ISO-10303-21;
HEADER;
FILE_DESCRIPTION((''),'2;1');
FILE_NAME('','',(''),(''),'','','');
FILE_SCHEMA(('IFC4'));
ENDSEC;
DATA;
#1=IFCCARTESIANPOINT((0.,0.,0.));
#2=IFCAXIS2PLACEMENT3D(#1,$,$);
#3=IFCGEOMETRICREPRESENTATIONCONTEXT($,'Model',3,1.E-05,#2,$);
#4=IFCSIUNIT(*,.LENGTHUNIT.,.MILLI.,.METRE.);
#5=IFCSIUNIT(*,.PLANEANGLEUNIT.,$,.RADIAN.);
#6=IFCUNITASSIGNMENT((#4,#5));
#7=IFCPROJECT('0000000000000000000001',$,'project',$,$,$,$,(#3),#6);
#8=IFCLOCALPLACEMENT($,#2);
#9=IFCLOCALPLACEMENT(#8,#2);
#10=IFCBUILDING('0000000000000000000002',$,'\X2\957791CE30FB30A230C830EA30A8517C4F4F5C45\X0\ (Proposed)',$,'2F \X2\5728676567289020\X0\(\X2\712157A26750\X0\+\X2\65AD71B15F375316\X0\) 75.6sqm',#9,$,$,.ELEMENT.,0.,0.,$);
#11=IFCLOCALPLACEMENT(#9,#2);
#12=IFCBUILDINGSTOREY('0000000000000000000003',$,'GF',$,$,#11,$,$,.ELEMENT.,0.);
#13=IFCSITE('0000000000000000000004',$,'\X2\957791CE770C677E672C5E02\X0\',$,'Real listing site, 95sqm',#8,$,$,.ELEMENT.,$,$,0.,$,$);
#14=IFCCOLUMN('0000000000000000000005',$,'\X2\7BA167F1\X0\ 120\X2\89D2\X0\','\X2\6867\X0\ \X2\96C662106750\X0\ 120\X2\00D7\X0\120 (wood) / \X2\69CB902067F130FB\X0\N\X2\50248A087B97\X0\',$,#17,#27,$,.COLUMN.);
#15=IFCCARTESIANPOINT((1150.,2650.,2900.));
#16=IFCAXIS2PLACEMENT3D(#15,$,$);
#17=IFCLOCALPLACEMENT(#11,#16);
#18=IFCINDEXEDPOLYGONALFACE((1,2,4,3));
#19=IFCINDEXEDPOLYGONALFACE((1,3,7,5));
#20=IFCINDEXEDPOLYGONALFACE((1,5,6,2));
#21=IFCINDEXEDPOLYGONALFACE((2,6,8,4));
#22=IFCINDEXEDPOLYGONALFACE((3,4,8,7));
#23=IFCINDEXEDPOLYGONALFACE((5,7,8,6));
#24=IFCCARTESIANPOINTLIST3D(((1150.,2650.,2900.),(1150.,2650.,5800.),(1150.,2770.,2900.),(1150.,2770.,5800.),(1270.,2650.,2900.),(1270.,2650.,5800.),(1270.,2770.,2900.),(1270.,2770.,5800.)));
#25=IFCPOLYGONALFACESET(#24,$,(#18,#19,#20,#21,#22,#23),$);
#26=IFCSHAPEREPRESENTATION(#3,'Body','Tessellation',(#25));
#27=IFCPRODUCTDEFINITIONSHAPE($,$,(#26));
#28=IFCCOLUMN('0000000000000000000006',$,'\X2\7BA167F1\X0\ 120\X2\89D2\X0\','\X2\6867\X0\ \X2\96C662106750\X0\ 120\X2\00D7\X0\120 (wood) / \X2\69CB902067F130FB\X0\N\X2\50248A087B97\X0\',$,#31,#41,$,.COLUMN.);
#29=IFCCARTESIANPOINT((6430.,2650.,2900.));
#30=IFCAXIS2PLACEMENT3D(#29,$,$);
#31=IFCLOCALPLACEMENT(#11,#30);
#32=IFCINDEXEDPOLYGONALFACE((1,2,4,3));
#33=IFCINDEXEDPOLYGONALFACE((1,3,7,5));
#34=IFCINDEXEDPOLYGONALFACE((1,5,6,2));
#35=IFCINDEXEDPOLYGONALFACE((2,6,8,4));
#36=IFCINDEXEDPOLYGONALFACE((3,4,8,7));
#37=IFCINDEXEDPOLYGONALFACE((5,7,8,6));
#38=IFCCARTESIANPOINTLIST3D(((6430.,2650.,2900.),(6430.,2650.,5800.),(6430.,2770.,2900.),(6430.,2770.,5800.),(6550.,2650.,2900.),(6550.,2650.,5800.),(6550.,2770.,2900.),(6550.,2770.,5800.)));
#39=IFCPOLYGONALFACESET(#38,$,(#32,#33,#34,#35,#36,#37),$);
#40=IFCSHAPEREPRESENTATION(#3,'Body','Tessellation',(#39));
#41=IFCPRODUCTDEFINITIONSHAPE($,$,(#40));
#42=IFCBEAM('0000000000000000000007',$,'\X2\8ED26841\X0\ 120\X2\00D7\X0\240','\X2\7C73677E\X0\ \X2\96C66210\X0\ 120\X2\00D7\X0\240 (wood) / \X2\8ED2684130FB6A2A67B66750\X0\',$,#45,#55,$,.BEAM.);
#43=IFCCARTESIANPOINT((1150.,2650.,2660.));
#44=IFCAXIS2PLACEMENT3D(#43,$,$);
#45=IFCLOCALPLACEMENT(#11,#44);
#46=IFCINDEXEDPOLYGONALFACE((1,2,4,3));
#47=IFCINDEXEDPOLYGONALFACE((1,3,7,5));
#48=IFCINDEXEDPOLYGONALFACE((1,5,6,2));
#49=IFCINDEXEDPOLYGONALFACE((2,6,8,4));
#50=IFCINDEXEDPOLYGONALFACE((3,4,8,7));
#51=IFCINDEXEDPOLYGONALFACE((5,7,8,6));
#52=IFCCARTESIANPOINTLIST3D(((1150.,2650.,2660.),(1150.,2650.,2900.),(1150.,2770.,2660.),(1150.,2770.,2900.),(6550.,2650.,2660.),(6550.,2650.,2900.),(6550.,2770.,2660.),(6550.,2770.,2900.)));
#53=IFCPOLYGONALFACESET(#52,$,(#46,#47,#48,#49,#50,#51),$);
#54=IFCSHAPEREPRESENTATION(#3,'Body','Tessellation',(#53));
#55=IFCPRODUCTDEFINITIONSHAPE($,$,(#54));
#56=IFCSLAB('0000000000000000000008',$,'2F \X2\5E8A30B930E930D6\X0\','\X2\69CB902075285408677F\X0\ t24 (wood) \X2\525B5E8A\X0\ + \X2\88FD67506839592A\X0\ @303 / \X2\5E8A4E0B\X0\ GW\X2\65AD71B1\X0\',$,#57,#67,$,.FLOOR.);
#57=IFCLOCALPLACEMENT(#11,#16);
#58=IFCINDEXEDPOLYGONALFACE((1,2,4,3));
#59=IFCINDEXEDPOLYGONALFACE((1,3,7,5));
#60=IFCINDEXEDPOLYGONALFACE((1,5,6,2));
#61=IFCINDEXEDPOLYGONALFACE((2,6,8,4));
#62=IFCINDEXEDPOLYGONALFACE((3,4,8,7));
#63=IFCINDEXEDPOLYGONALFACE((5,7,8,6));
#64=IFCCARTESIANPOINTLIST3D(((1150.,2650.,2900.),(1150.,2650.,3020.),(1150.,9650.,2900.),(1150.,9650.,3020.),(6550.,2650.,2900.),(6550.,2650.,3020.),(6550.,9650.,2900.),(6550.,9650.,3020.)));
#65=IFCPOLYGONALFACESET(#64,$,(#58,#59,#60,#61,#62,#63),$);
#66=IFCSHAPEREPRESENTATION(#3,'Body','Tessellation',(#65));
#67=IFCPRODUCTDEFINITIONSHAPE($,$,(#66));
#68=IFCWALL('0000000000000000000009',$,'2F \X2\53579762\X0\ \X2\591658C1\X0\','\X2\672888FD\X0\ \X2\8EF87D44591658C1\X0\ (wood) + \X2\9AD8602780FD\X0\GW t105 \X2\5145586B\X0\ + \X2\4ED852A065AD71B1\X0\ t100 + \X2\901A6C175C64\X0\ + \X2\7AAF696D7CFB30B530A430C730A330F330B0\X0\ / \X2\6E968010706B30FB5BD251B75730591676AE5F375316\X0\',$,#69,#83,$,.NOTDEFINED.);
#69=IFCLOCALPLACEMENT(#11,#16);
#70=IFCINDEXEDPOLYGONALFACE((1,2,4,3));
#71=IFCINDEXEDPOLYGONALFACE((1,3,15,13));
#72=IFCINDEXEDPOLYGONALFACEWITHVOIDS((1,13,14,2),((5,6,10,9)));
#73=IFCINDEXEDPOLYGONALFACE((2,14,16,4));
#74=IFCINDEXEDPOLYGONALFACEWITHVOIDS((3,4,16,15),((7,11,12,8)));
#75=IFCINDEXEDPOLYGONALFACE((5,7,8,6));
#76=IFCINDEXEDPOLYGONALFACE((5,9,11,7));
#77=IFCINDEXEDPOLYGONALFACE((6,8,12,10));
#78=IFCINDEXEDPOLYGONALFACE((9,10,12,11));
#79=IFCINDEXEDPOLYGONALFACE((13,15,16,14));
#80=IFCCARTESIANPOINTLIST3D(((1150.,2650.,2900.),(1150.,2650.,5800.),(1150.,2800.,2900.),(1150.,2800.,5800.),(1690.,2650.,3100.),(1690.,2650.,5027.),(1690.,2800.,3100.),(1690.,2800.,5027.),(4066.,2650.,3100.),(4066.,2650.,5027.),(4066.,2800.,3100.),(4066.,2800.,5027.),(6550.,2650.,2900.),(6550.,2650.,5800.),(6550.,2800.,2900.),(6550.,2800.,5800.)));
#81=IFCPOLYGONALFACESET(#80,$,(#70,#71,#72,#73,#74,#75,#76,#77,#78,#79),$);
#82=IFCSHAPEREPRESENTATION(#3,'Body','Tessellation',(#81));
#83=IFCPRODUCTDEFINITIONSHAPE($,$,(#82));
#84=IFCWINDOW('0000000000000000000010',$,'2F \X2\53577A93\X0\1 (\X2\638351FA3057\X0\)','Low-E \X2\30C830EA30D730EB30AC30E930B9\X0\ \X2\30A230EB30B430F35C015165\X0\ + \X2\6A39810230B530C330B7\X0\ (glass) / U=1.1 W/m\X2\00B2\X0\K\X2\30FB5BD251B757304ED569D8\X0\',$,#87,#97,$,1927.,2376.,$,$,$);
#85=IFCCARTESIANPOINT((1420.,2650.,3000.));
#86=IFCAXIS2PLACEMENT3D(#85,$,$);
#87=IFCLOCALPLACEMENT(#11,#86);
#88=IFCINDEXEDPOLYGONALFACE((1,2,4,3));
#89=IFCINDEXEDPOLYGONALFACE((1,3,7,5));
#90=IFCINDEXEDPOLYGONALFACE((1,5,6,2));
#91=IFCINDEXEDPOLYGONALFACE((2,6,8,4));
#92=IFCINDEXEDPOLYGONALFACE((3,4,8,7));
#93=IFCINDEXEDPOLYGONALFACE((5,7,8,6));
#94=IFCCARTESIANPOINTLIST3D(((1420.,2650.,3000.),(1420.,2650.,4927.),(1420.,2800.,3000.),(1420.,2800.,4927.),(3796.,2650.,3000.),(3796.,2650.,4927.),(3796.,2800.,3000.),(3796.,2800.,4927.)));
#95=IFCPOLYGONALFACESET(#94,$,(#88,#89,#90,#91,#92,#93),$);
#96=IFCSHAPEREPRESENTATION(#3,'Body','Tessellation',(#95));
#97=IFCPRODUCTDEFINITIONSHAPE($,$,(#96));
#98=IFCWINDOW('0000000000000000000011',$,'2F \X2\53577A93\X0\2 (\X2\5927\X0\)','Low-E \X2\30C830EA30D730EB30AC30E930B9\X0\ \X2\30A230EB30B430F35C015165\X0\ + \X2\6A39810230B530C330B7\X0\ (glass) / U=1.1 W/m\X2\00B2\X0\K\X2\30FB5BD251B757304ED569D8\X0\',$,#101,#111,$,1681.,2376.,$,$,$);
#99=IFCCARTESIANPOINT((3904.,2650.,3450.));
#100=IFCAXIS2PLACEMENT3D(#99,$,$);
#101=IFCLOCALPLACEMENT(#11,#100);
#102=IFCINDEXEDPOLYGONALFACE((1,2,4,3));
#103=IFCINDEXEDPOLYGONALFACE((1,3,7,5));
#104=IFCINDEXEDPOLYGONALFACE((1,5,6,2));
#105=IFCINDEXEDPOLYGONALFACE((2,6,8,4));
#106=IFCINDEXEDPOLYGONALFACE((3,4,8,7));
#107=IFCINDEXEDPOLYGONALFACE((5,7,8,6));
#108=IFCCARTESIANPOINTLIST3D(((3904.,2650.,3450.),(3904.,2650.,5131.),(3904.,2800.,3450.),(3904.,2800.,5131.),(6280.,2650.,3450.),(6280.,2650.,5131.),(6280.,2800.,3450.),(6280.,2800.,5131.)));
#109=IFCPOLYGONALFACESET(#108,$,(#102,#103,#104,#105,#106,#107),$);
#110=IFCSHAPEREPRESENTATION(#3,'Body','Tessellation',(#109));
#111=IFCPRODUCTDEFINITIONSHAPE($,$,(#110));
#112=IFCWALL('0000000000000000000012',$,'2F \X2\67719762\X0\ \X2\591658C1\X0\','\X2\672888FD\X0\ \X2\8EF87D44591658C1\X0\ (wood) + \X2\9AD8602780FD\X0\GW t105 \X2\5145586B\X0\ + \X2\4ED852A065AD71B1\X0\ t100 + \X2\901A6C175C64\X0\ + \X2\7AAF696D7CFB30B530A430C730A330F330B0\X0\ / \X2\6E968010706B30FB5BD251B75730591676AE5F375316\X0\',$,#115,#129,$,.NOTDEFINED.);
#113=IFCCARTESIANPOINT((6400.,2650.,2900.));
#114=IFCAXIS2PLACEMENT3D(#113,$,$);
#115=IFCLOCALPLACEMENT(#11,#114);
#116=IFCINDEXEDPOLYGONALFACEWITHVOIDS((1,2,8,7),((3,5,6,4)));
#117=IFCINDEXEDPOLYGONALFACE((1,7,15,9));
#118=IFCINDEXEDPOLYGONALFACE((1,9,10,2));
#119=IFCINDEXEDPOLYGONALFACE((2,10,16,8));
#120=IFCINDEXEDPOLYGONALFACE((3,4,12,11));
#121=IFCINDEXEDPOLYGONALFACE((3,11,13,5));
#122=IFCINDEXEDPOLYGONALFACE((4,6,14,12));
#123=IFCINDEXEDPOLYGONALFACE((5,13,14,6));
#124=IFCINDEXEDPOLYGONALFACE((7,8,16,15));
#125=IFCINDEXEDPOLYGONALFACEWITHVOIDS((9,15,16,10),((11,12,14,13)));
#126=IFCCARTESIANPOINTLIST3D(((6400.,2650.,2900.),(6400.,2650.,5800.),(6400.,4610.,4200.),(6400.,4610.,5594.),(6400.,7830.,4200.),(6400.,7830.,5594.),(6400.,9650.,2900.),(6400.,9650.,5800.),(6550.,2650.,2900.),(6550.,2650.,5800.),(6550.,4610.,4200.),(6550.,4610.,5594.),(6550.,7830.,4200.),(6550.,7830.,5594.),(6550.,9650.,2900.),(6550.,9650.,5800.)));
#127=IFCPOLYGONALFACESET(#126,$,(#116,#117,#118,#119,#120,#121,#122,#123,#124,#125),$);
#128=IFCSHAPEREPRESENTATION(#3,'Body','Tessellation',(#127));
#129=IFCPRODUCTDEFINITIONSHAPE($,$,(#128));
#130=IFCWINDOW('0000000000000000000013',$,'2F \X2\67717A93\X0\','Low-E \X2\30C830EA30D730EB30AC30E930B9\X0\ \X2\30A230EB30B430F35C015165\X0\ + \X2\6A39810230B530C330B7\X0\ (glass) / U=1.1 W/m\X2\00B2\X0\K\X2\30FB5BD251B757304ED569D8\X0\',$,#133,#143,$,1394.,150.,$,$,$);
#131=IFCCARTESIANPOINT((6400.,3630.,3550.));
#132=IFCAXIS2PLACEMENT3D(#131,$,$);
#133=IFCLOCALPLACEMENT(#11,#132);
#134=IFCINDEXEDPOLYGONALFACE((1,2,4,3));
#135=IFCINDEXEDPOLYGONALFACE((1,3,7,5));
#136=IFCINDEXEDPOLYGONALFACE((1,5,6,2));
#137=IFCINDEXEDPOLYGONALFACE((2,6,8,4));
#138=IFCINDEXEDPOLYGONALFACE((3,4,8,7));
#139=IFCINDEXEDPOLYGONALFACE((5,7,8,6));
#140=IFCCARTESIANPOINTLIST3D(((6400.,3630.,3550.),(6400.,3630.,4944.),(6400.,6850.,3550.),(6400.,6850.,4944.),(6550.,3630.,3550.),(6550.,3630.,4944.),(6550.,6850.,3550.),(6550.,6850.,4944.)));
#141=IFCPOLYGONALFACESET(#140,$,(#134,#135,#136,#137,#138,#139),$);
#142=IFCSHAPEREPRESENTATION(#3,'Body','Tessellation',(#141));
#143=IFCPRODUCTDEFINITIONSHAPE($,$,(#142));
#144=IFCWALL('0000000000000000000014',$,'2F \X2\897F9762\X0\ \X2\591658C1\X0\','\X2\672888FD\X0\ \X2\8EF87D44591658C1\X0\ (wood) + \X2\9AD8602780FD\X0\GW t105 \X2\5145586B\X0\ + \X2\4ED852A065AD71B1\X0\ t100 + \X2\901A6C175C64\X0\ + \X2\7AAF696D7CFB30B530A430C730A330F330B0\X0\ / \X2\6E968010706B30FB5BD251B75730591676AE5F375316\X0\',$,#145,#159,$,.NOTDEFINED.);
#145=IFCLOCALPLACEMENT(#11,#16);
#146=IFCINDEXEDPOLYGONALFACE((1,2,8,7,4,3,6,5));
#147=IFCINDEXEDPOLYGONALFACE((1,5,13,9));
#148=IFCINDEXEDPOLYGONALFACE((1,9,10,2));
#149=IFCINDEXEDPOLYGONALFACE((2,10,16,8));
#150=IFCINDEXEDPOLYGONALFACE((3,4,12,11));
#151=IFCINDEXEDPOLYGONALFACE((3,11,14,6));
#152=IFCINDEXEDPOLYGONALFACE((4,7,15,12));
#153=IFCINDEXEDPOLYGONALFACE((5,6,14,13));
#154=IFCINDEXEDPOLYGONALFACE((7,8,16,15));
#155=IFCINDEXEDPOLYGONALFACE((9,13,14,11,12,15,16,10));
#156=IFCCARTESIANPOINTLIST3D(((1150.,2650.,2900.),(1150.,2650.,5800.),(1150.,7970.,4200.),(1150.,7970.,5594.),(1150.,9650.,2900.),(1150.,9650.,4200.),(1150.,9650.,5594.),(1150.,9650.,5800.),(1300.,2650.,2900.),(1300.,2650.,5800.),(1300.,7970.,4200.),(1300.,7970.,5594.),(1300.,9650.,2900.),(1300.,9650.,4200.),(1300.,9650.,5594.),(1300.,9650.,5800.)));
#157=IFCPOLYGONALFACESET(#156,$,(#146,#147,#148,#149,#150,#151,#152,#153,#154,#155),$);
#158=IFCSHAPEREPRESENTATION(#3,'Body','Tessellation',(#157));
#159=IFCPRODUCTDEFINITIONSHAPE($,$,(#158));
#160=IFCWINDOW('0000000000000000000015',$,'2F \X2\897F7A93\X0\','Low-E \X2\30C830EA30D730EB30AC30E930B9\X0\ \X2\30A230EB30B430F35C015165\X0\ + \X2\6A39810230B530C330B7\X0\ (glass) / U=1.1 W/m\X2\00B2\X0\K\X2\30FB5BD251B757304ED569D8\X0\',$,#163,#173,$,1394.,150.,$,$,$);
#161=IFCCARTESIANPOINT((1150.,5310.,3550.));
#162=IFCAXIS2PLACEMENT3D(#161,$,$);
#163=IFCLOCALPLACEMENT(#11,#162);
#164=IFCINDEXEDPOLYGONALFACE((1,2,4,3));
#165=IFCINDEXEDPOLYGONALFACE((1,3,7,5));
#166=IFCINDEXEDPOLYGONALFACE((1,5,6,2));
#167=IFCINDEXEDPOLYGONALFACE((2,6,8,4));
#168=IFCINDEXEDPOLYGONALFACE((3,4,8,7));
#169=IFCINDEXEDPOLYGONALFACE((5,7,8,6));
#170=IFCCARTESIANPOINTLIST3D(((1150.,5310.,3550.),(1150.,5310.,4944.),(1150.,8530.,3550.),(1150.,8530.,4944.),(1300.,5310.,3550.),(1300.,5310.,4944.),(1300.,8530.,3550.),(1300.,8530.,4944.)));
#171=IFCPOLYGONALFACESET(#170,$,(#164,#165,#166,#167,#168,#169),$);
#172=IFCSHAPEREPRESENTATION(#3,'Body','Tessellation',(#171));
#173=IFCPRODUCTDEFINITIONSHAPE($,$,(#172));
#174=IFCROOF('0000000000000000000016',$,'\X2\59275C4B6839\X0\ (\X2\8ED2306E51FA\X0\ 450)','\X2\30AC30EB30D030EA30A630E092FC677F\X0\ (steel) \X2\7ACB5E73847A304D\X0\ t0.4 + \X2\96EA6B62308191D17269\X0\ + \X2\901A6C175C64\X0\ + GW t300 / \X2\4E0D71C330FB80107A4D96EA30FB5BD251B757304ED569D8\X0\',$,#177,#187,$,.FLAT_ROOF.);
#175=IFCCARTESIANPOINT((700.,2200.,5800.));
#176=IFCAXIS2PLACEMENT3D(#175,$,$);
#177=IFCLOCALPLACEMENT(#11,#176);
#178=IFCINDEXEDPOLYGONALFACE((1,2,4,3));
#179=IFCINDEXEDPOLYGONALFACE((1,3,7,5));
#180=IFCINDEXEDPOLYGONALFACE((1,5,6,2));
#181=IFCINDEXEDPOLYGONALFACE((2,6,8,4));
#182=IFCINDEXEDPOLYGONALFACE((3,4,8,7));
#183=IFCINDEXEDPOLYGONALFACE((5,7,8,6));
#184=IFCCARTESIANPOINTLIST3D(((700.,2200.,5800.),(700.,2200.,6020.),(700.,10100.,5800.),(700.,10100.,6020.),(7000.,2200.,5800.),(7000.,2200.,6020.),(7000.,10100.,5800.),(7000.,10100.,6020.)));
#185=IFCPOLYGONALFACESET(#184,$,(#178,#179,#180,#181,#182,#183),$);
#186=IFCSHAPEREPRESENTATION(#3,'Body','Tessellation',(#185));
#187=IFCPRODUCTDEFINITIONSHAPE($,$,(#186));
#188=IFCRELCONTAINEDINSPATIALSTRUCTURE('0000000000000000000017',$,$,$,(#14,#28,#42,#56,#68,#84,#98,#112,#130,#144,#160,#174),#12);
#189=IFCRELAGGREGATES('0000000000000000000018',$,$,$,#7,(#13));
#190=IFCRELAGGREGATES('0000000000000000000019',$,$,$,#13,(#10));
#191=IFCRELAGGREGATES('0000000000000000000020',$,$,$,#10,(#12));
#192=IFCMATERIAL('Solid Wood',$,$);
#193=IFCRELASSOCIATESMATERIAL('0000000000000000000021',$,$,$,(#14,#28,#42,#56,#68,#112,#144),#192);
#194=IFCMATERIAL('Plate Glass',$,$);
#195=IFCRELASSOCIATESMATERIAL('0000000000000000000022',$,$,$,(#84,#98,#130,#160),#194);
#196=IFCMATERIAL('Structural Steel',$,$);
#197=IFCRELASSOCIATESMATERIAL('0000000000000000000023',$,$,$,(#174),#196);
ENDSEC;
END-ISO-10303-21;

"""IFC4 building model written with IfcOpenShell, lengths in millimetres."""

from ifc_helpers import new_model, si_unit, frame, frame_2d, origin, place, context, project, spatial, rectangle, extrude, material, element, fill, save


model = new_model("IFC4")

# Units and contexts
model_context = context("Model", 3, precision=1e-05, world=origin())
ifc_project = project(units=[si_unit("LENGTHUNIT", "METRE", prefix="MILLI"), si_unit("PLANEANGLEUNIT", "RADIAN")], contexts=[model_context])

# Site, building, storey
site_placement = place(None, origin())
site = spatial("IfcSite", under=ifc_project, at=site_placement, Name="長野県松本市", ObjectType="Real listing site, 95sqm", CompositionType="ELEMENT", RefElevation=0.0)
building_placement = place(site_placement, origin())
building = spatial("IfcBuilding", under=site, at=building_placement, Name="長野・アトリエ兼住居 (Proposed)", ObjectType="2F 在来木造(無垢材+断熱強化) 75.6sqm", CompositionType="ELEMENT", ElevationOfRefHeight=0.0, ElevationOfTerrain=0.0)
storey_placement = place(building_placement, origin())
storey = spatial("IfcBuildingStorey", under=building, at=storey_placement, Name="GF", CompositionType="ELEMENT", Elevation=0.0)

# Columns
ifc_material_1 = material(Name="Solid Wood")
column_1_placement = place(storey_placement, frame((1150.0, 2650.0, 2900.0)))
element("IfcColumn", 1, at=column_1_placement, inside=storey, material=ifc_material_1, Name="管柱 120角", Description="桧 集成材 120×120 (wood) / 構造柱・N値計算", PredefinedType="COLUMN", context=model_context, shape_type="SweptSolid", body=[
    extrude(rectangle(XDim=120.0, YDim=120.0, at=frame_2d((60.0, 60.0))), frame((1150.0, 2650.0, 2900.0)), (0.0, 0.0, 1.0), 2900.0),
])
column_2_placement = place(storey_placement, frame((6430.0, 2650.0, 2900.0)))
element("IfcColumn", 2, at=column_2_placement, inside=storey, material=ifc_material_1, Name="管柱 120角", Description="桧 集成材 120×120 (wood) / 構造柱・N値計算", PredefinedType="COLUMN", context=model_context, shape_type="SweptSolid", body=[
    extrude(rectangle(XDim=120.0, YDim=120.0, at=frame_2d((60.0, 60.0))), frame((6430.0, 2650.0, 2900.0)), (0.0, 0.0, 1.0), 2900.0),
])

# Beam
beam_1_placement = place(storey_placement, frame((1150.0, 2650.0, 2660.0)))
element("IfcBeam", 3, at=beam_1_placement, inside=storey, material=ifc_material_1, Name="軒桁 120×240", Description="米松 集成 120×240 (wood) / 軒桁・横架材", PredefinedType="BEAM", context=model_context, shape_type="SweptSolid", body=[
    extrude(rectangle(XDim=5400.0, YDim=120.0, at=frame_2d((2700.0, 60.0))), frame((1150.0, 2650.0, 2660.0)), (0.0, 0.0, 1.0), 240.0),
])

# Slab
slab_placement = place(storey_placement, frame((1150.0, 2650.0, 2900.0)))
element("IfcSlab", 4, at=slab_placement, inside=storey, material=ifc_material_1, Name="2F 床スラブ", Description="構造用合板 t24 (wood) 剛床 + 製材根太 @303 / 床下 GW断熱", PredefinedType="FLOOR", context=model_context, shape_type="SweptSolid", body=[
    extrude(rectangle(XDim=5400.0, YDim=7000.0, at=frame_2d((2700.0, 3500.0))), frame((1150.0, 2650.0, 2900.0)), (0.0, 0.0, 1.0), 120.0),
])

# Wall, openings, windows
wall_1_placement = place(storey_placement, frame((1150.0, 2650.0, 2900.0)))
wall_1 = element("IfcWall", 5, at=wall_1_placement, inside=storey, material=ifc_material_1, Name="2F 南面 外壁", Description="木製 軸組外壁 (wood) + 高性能GW t105 充填 + 付加断熱 t100 + 通気層 + 窯業系サイディング / 準耐火・寒冷地外皮強化", PredefinedType="NOTDEFINED", context=model_context, shape_type="SweptSolid", body=[
    extrude(rectangle(XDim=5400.0, YDim=150.0, at=frame_2d((2700.0, 75.0))), frame((1150.0, 2650.0, 2900.0)), (0.0, 0.0, 1.0), 2900.0),
])
opening_1_placement = place(storey_placement, frame((1420.0, 2650.0, 3000.0)))
opening_1 = element("IfcOpeningElement", 6, at=opening_1_placement, cuts=wall_1, PredefinedType="NOTDEFINED", context=model_context, shape_type="SweptSolid", body=[
    extrude(rectangle(XDim=2376.0, YDim=150.0, at=frame_2d((1188.0, 75.0))), frame((1420.0, 2650.0, 3000.0)), (0.0, 0.0, 1.0), 1927.0),
])
opening_2_placement = place(storey_placement, frame((3904.0, 2650.0, 3450.0)))
opening_2 = element("IfcOpeningElement", 7, at=opening_2_placement, cuts=wall_1, PredefinedType="NOTDEFINED", context=model_context, shape_type="SweptSolid", body=[
    extrude(rectangle(XDim=2376.0, YDim=150.0, at=frame_2d((1188.0, 75.0))), frame((3904.0, 2650.0, 3450.0)), (0.0, 0.0, 1.0), 1681.0),
])
ifc_material_2 = material(Name="Plate Glass")
window_1_placement = place(storey_placement, frame((1420.0, 2650.0, 3000.0)))
window_1 = element("IfcWindow", 8, at=window_1_placement, inside=storey, material=ifc_material_2, Name="2F 南窓1 (掃出し)", Description="Low-E トリプルガラス アルゴン封入 + 樹脂サッシ (glass) / U=1.1 W/m²K・寒冷地仕様", OverallHeight=1927.0, OverallWidth=2376.0, context=model_context, shape_type="SweptSolid", body=[
    extrude(rectangle(XDim=2376.0, YDim=150.0, at=frame_2d((1188.0, 75.0))), frame((1420.0, 2650.0, 3000.0)), (0.0, 0.0, 1.0), 1927.0),
])
fill(opening_1, window_1)
window_2_placement = place(storey_placement, frame((3904.0, 2650.0, 3450.0)))
window_2 = element("IfcWindow", 9, at=window_2_placement, inside=storey, material=ifc_material_2, Name="2F 南窓2 (大)", Description="Low-E トリプルガラス アルゴン封入 + 樹脂サッシ (glass) / U=1.1 W/m²K・寒冷地仕様", OverallHeight=1681.0, OverallWidth=2376.0, context=model_context, shape_type="SweptSolid", body=[
    extrude(rectangle(XDim=2376.0, YDim=150.0, at=frame_2d((1188.0, 75.0))), frame((3904.0, 2650.0, 3450.0)), (0.0, 0.0, 1.0), 1681.0),
])
fill(opening_2, window_2)

# Walls, openings, windows
wall_2_placement = place(storey_placement, frame((6400.0, 2650.0, 2900.0)))
wall_2 = element("IfcWall", 10, at=wall_2_placement, inside=storey, material=ifc_material_1, Name="2F 東面 外壁", Description="木製 軸組外壁 (wood) + 高性能GW t105 充填 + 付加断熱 t100 + 通気層 + 窯業系サイディング / 準耐火・寒冷地外皮強化", PredefinedType="NOTDEFINED", context=model_context, shape_type="SweptSolid", body=[
    extrude(rectangle(XDim=150.0, YDim=7000.0, at=frame_2d((75.0, 3500.0))), frame((6400.0, 2650.0, 2900.0)), (0.0, 0.0, 1.0), 2900.0),
])
opening_3_placement = place(storey_placement, frame((6400.0, 3630.0, 3550.0)))
opening_3 = element("IfcOpeningElement", 11, at=opening_3_placement, cuts=wall_2, PredefinedType="NOTDEFINED", context=model_context, shape_type="SweptSolid", body=[
    extrude(rectangle(XDim=150.0, YDim=3220.0, at=frame_2d((75.0, 1610.0))), frame((6400.0, 3630.0, 3550.0)), (0.0, 0.0, 1.0), 1394.0),
])
window_3_placement = place(storey_placement, frame((6400.0, 3630.0, 3550.0)))
window_3 = element("IfcWindow", 12, at=window_3_placement, inside=storey, material=ifc_material_2, Name="2F 東窓", Description="Low-E トリプルガラス アルゴン封入 + 樹脂サッシ (glass) / U=1.1 W/m²K・寒冷地仕様", OverallHeight=1394.0, OverallWidth=150.0, context=model_context, shape_type="SweptSolid", body=[
    extrude(rectangle(XDim=150.0, YDim=3220.0, at=frame_2d((75.0, 1610.0))), frame((6400.0, 3630.0, 3550.0)), (0.0, 0.0, 1.0), 1394.0),
])
fill(opening_3, window_3)
wall_3_placement = place(storey_placement, frame((1150.0, 2650.0, 2900.0)))
wall_3 = element("IfcWall", 13, at=wall_3_placement, inside=storey, material=ifc_material_1, Name="2F 西面 外壁", Description="木製 軸組外壁 (wood) + 高性能GW t105 充填 + 付加断熱 t100 + 通気層 + 窯業系サイディング / 準耐火・寒冷地外皮強化", PredefinedType="NOTDEFINED", context=model_context, shape_type="SweptSolid", body=[
    extrude(rectangle(XDim=150.0, YDim=7000.0, at=frame_2d((75.0, 3500.0))), frame((1150.0, 2650.0, 2900.0)), (0.0, 0.0, 1.0), 2900.0),
])
opening_4_placement = place(storey_placement, frame((1150.0, 5310.0, 3550.0)))
opening_4 = element("IfcOpeningElement", 14, at=opening_4_placement, cuts=wall_3, PredefinedType="NOTDEFINED", context=model_context, shape_type="SweptSolid", body=[
    extrude(rectangle(XDim=150.0, YDim=3220.0, at=frame_2d((75.0, 1610.0))), frame((1150.0, 5310.0, 3550.0)), (0.0, 0.0, 1.0), 1394.0),
])
window_4_placement = place(storey_placement, frame((1150.0, 5310.0, 3550.0)))
window_4 = element("IfcWindow", 15, at=window_4_placement, inside=storey, material=ifc_material_2, Name="2F 西窓", Description="Low-E トリプルガラス アルゴン封入 + 樹脂サッシ (glass) / U=1.1 W/m²K・寒冷地仕様", OverallHeight=1394.0, OverallWidth=150.0, context=model_context, shape_type="SweptSolid", body=[
    extrude(rectangle(XDim=150.0, YDim=3220.0, at=frame_2d((75.0, 1610.0))), frame((1150.0, 5310.0, 3550.0)), (0.0, 0.0, 1.0), 1394.0),
])
fill(opening_4, window_4)

# Roof
ifc_material_3 = material(Name="Structural Steel")
roof_placement = place(storey_placement, frame((700.0, 2200.0, 5800.0)))
element("IfcRoof", 16, at=roof_placement, inside=storey, material=ifc_material_3, Name="大屋根 (軒の出 450)", Description="ガルバリウム鋼板 (steel) 立平葺き t0.4 + 雪止め金物 + 通気層 + GW t300 / 不燃・耐積雪・寒冷地仕様", PredefinedType="FLAT_ROOF", context=model_context, shape_type="SweptSolid", body=[
    extrude(rectangle(XDim=6300.0, YDim=7900.0, at=frame_2d((3150.0, 3950.0))), frame((700.0, 2200.0, 5800.0)), (0.0, 0.0, 1.0), 220.0),
])

save(model, "model.ifc")
